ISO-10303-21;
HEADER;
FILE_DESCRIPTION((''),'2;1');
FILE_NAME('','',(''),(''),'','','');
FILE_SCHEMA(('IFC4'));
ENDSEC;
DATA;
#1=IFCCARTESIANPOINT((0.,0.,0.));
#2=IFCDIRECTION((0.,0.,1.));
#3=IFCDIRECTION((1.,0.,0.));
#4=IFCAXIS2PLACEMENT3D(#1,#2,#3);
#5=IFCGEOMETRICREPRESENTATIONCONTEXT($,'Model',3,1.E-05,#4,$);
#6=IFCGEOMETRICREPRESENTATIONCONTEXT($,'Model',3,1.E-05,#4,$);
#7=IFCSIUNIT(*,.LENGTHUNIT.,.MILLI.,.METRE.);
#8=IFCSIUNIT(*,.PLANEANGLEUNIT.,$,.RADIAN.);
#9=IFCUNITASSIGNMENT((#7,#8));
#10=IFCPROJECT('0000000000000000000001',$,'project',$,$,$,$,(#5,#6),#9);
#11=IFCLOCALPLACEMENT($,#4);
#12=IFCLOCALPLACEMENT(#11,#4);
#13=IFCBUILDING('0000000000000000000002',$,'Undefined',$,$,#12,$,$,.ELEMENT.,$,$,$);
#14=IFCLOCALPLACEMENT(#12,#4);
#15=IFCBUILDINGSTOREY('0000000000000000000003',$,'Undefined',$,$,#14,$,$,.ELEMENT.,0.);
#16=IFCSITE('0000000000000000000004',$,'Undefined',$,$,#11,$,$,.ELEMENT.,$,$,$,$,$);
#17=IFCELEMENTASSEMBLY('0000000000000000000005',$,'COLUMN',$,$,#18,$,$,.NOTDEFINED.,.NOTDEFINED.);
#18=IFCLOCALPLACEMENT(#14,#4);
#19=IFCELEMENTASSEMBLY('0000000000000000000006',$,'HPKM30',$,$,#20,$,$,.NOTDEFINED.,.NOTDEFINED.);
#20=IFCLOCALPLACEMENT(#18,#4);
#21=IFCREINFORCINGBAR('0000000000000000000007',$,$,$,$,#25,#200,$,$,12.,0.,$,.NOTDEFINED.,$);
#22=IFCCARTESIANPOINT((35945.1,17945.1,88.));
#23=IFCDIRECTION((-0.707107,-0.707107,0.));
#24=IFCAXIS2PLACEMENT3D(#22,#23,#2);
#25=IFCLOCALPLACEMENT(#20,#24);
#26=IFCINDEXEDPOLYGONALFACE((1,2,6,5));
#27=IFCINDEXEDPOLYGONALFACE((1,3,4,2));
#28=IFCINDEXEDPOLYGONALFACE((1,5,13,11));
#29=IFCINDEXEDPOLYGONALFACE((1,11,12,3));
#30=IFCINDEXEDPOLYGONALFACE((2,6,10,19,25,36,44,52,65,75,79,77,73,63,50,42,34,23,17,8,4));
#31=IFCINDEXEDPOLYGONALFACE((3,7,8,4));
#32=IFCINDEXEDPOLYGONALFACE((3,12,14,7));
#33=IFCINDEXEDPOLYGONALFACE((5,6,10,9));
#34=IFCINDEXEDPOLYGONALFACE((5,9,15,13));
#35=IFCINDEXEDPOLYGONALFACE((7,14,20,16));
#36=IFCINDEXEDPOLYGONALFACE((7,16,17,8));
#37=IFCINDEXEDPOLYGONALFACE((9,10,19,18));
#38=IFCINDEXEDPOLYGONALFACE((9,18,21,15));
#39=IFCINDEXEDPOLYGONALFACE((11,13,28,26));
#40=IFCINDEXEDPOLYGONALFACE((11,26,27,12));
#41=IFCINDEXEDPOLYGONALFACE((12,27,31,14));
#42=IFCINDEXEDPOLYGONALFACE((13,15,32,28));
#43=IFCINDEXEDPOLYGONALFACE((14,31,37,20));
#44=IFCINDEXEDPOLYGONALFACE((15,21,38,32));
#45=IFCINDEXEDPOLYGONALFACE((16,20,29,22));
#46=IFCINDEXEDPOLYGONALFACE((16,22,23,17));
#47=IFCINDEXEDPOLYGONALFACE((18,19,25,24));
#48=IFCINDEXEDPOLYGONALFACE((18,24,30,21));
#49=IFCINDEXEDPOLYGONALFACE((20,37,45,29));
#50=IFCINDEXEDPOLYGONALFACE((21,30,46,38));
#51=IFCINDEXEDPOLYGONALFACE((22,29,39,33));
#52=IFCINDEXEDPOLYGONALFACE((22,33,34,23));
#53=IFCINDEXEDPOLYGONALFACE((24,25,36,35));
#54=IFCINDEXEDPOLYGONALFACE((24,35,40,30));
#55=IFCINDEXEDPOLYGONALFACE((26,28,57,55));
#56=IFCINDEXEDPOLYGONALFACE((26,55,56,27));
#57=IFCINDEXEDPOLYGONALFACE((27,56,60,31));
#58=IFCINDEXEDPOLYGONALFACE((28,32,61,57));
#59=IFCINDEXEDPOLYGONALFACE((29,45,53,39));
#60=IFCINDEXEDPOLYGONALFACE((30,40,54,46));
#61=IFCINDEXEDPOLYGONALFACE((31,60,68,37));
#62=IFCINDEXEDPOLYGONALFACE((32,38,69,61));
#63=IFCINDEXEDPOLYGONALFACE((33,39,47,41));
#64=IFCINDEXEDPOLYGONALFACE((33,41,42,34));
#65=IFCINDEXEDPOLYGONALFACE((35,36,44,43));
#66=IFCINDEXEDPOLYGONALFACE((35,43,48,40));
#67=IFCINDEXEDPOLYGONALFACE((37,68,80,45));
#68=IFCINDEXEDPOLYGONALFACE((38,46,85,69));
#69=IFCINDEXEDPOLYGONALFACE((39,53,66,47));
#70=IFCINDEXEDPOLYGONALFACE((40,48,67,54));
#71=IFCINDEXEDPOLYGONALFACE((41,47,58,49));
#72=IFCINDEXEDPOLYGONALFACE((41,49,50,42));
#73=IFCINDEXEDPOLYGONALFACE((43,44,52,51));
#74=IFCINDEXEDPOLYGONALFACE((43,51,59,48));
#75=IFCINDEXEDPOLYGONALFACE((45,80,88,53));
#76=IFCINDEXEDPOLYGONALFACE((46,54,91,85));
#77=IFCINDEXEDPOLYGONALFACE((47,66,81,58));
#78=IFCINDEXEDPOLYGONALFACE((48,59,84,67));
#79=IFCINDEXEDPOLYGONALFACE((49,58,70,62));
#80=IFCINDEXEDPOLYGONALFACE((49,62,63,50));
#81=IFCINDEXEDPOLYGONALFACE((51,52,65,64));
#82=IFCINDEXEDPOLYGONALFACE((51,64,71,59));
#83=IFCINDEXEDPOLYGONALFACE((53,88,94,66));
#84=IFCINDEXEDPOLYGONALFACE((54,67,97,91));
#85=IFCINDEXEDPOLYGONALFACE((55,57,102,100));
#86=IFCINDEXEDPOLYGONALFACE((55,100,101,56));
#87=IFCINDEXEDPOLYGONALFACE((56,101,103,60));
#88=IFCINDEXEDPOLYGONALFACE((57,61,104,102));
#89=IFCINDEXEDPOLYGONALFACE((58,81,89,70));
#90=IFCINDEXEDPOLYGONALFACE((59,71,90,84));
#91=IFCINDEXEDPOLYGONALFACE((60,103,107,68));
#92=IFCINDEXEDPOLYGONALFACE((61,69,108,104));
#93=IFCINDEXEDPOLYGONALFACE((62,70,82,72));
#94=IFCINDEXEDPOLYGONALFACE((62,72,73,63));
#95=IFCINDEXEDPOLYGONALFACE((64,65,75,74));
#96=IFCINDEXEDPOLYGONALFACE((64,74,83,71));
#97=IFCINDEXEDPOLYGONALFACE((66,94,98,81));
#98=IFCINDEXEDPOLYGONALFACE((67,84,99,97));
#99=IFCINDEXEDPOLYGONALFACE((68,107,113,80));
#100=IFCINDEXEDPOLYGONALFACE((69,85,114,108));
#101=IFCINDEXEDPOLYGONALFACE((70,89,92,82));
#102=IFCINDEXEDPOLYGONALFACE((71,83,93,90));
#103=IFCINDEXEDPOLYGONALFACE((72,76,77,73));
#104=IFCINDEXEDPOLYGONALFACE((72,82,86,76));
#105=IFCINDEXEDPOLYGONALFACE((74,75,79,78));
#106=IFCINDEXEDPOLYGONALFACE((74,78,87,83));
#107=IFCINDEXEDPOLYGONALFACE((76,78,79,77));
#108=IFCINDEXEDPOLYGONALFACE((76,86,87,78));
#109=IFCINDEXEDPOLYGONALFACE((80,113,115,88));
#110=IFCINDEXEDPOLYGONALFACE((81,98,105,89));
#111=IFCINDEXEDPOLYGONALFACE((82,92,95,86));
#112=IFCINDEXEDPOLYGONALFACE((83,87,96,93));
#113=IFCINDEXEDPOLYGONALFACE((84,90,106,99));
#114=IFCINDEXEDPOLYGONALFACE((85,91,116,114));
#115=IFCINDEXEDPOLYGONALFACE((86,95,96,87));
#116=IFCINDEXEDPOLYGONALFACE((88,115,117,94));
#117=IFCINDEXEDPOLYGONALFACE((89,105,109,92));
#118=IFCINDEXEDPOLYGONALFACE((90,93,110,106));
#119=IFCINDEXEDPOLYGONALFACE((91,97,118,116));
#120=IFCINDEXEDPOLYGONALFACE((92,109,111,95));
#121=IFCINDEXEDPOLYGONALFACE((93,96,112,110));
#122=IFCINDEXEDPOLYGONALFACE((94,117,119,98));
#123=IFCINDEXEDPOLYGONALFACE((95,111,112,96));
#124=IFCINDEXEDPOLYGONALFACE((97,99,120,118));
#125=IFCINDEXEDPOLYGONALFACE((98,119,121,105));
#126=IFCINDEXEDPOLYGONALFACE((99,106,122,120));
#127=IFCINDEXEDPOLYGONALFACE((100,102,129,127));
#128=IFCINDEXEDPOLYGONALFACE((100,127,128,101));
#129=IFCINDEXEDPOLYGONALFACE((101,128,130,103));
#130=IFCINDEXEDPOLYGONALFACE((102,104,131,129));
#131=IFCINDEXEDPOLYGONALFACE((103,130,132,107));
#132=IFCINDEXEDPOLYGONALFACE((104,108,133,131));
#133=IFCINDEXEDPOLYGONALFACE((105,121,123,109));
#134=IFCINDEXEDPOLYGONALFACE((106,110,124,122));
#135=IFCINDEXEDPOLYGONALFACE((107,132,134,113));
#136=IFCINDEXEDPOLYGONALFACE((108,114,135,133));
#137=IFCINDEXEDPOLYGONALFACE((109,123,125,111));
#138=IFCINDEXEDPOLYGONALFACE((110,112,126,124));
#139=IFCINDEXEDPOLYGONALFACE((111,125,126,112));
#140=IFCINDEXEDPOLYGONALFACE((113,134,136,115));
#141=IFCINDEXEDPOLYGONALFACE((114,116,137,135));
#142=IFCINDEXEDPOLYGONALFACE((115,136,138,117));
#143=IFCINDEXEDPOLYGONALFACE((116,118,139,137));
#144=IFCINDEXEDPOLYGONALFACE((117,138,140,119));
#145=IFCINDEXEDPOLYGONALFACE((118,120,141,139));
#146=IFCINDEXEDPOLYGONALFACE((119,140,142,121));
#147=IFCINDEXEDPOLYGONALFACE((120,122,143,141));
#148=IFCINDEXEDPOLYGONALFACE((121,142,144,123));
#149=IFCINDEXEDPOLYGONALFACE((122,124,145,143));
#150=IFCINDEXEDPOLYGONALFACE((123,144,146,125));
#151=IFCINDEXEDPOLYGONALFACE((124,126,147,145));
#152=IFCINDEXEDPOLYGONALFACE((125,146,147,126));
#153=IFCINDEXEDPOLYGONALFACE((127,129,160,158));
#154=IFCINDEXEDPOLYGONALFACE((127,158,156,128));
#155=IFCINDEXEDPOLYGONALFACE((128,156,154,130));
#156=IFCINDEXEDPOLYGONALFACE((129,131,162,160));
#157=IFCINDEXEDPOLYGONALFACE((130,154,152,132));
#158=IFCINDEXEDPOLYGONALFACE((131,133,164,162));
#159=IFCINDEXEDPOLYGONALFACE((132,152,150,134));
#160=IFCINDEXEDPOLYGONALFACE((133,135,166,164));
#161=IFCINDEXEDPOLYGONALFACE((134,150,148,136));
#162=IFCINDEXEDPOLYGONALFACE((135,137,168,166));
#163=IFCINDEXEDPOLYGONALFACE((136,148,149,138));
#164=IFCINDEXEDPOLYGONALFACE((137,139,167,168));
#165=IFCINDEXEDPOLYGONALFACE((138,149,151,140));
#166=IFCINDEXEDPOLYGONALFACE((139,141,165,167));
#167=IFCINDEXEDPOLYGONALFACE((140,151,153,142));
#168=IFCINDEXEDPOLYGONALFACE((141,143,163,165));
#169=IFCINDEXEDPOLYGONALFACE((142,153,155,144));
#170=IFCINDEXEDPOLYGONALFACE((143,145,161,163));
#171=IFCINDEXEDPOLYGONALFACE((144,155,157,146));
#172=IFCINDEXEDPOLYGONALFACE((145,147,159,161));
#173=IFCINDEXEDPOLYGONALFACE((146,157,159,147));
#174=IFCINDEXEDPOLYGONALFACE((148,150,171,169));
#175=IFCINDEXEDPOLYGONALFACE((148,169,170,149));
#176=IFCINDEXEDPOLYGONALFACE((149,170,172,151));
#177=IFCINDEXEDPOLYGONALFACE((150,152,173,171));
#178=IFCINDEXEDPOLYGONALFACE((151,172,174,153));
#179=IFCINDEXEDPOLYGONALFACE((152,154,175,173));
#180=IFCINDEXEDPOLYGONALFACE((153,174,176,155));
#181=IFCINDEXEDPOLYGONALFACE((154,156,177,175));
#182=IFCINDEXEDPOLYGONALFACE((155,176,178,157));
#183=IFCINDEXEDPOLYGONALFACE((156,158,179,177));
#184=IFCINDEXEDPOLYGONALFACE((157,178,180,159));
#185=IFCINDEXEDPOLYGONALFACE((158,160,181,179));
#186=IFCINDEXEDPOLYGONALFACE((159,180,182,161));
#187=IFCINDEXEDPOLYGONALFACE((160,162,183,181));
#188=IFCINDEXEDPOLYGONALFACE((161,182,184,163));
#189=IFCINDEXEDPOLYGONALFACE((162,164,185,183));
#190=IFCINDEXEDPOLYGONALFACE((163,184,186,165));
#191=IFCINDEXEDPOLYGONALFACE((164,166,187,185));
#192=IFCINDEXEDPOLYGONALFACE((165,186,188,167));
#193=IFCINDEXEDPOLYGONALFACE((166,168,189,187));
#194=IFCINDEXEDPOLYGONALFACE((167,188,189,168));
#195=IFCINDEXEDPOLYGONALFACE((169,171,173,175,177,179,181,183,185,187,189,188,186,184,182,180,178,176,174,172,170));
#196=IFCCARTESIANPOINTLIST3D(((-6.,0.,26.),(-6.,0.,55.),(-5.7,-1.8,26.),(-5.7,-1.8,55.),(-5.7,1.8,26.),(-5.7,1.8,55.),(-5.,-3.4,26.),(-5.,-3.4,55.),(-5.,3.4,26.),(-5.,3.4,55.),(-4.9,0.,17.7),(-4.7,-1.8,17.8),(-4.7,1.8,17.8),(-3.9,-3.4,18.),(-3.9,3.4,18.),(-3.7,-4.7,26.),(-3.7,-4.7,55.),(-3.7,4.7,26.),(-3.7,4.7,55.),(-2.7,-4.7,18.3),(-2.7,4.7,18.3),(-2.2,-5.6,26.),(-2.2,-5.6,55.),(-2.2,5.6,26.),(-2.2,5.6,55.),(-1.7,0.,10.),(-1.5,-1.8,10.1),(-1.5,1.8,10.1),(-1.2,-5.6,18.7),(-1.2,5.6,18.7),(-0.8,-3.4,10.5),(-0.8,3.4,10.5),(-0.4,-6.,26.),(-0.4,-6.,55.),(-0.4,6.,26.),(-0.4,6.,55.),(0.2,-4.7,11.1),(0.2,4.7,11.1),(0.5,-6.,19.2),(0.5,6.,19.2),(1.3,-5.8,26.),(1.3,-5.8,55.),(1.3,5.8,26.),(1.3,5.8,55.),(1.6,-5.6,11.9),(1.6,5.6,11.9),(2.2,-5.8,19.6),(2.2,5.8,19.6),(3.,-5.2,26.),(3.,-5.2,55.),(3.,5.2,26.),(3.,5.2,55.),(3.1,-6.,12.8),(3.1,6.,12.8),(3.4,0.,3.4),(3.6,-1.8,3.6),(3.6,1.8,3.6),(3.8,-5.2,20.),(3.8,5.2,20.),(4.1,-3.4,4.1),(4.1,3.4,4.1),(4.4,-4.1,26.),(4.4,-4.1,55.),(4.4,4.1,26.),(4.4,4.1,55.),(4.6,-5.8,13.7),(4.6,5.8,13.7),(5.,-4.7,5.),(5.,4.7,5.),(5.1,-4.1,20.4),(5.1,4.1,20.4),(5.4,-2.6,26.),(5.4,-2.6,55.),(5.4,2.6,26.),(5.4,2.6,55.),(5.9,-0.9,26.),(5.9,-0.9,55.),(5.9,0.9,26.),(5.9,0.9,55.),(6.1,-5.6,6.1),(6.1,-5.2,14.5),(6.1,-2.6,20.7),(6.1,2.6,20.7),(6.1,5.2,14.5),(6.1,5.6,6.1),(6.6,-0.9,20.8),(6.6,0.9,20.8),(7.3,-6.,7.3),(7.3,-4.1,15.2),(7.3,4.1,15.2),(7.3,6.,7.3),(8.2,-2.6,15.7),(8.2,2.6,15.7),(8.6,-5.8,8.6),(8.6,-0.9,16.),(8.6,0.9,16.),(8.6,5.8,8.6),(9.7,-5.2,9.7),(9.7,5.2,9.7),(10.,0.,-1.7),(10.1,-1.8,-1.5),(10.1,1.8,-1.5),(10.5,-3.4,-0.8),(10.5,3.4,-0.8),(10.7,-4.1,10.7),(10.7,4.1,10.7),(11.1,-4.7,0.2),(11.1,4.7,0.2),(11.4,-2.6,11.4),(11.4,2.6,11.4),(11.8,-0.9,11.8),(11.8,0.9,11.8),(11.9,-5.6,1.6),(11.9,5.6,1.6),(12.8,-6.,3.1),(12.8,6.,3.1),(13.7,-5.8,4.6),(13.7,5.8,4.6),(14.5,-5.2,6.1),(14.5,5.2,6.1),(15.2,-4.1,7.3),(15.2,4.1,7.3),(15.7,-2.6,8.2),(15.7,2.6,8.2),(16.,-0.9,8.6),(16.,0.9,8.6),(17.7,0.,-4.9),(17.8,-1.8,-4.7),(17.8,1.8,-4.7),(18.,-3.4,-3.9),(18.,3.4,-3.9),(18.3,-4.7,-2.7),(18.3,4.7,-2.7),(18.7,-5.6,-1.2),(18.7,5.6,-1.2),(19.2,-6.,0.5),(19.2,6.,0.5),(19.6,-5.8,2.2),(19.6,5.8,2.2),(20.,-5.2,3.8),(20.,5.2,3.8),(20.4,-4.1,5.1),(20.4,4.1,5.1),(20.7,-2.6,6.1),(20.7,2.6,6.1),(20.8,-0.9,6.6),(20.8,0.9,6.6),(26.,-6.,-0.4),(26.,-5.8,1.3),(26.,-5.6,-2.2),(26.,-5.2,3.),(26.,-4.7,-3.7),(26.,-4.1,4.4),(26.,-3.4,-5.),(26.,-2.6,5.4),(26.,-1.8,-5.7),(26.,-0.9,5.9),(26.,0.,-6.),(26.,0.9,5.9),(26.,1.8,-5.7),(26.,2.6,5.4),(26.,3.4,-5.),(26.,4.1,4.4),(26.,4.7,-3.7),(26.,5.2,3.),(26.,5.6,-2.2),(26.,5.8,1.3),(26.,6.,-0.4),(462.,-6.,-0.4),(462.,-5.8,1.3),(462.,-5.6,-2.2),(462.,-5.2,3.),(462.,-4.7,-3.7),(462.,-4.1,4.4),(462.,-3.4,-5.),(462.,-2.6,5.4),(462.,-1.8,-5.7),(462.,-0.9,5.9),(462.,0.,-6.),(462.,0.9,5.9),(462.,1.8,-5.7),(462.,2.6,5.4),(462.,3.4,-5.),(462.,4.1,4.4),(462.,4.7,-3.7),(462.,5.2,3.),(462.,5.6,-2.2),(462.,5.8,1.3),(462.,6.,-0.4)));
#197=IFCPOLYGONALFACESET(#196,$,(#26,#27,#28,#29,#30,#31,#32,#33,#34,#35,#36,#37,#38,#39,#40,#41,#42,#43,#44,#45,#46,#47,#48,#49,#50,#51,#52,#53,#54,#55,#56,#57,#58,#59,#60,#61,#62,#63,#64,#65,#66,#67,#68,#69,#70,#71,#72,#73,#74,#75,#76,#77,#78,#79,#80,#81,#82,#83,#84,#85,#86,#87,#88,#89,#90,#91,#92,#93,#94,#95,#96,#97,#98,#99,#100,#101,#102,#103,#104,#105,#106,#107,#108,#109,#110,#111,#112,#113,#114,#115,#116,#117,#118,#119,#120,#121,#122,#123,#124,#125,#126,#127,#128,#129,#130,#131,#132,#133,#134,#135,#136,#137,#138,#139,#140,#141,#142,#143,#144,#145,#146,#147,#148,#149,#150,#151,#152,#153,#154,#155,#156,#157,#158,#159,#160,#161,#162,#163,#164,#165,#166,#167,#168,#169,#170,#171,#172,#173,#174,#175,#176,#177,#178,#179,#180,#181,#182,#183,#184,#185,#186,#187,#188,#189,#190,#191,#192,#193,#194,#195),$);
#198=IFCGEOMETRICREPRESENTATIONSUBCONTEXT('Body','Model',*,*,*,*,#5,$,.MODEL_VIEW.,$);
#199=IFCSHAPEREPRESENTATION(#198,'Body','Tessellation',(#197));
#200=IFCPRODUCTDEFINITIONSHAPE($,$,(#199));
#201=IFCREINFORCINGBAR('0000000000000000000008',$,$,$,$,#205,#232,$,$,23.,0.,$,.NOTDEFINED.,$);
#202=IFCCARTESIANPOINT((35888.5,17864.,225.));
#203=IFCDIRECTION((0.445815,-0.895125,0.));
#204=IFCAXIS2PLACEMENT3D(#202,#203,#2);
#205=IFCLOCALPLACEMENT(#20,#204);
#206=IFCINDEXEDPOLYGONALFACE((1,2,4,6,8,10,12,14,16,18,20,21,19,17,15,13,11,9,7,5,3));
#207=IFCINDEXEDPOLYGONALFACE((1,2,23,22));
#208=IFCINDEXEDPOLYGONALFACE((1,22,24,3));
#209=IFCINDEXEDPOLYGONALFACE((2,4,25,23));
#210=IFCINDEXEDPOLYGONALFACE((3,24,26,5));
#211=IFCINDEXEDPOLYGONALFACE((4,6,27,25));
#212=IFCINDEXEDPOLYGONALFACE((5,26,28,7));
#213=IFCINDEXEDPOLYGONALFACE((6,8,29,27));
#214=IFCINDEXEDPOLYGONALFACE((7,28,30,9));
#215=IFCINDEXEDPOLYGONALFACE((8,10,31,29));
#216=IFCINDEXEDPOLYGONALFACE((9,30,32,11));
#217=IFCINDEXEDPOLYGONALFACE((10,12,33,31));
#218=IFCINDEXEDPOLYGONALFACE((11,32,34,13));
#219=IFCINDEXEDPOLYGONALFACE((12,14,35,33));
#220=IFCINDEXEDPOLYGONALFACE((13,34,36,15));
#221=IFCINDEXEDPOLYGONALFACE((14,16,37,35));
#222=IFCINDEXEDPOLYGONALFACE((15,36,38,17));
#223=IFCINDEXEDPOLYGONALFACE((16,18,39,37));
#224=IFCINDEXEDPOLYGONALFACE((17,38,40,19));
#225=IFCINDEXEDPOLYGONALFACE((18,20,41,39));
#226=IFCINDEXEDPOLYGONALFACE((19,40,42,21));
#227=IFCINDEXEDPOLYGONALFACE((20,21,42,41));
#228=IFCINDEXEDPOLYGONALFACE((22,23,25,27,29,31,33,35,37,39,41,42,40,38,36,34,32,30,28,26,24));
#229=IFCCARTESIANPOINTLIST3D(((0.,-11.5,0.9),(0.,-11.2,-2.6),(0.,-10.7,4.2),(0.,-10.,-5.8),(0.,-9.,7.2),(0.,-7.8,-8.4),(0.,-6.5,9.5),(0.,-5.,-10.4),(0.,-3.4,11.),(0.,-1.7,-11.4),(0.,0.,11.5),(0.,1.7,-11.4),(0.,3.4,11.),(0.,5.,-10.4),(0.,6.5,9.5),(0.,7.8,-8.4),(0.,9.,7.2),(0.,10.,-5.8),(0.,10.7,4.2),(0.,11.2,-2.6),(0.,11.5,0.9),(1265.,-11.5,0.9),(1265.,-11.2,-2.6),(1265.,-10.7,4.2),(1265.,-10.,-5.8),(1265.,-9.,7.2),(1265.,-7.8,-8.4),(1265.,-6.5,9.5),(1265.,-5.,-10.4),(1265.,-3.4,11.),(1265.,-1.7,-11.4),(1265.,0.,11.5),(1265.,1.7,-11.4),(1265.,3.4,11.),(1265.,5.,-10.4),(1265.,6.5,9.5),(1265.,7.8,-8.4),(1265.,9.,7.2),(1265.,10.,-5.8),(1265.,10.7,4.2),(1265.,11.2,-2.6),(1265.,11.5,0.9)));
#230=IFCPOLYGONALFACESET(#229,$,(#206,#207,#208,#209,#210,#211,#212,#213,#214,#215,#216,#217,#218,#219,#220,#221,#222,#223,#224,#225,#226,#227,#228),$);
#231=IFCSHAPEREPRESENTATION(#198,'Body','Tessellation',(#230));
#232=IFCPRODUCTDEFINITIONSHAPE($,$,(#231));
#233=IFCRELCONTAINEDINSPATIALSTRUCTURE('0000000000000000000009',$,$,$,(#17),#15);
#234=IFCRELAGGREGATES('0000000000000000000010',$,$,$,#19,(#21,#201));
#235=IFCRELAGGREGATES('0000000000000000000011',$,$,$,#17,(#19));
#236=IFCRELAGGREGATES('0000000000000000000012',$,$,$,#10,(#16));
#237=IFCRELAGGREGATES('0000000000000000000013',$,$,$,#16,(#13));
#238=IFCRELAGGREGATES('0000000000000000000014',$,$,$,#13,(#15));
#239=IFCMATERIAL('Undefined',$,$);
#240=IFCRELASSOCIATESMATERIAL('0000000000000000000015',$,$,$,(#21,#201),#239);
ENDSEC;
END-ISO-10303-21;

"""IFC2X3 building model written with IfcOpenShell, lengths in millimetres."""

from ifc_helpers import new_model, entity, si_unit, frame, origin_with_axes, place, context, subcontext, project, spatial, source, transform, mapped, material, element, aggregate, save


model = new_model("IFC2X3")

# Units and contexts
model_context_1 = context("Model", 3, precision=1e-05, world=origin_with_axes())
model_context_2 = context("Model", 3, precision=1e-05, world=origin_with_axes())
body_context = subcontext(model_context_1, "Body", "Model", "MODEL_VIEW")
ifc_project = project(units=[si_unit("LENGTHUNIT", "METRE", prefix="MILLI"), si_unit("PLANEANGLEUNIT", "RADIAN")], contexts=[model_context_1, model_context_2])

# Site, building, storey
site_placement = place(None, origin_with_axes())
site = spatial("IfcSite", under=ifc_project, at=site_placement, Name="Undefined", CompositionType="ELEMENT")
building_placement = place(site_placement, origin_with_axes())
building = spatial("IfcBuilding", under=site, at=building_placement, Name="Undefined", CompositionType="ELEMENT")
storey_placement = place(building_placement, origin_with_axes())
storey = spatial("IfcBuildingStorey", under=building, at=storey_placement, Name="Undefined", CompositionType="ELEMENT", Elevation=0.0)

# Element assembly
assembly_1_placement = place(storey_placement, origin_with_axes())
assembly_1 = element("IfcElementAssembly", 1, at=assembly_1_placement, inside=storey, Name="COLUMN", AssemblyPlace="NOTDEFINED", PredefinedType="NOTDEFINED")

# Element assembly
assembly_2_placement = place(assembly_1_placement, origin_with_axes())
assembly_2 = element("IfcElementAssembly", 2, at=assembly_2_placement, Name="HPKM30", AssemblyPlace="NOTDEFINED", PredefinedType="NOTDEFINED")

# Shared definitions
ifc_material_1 = material(Name="Undefined")

# Reinforcing bars
shared_shape_1 = source(origin_with_axes(), body_context, "Body", "AdvancedSweptSolid", [
    entity("IfcSweptDiskSolid", entity("IfcCompositeCurve", [entity("IfcCompositeCurveSegment", "CONTINUOUS", True, entity("IfcTrimmedCurve", entity("IfcLine", entity("IfcCartesianPoint", [0.0, 0.0, 0.0]), entity("IfcVector", entity("IfcDirection", [0.0, 0.0, -1.0]), 1.0)), [entity("IfcParameterValue", 0.0)], [entity("IfcParameterValue", 29.0)], True, "PARAMETER")), entity("IfcCompositeCurveSegment", "CONTINUOUS", True, entity("IfcTrimmedCurve", entity("IfcCircle", entity("IfcAxis2Placement3D", entity("IfcCartesianPoint", [26.0, 0.0, -29.0]), entity("IfcDirection", [0.0, -1.0, 0.0]), entity("IfcDirection", [-1.0, 0.0, 0.0])), 26.0), [entity("IfcParameterValue", 0.0)], [entity("IfcParameterValue", 1.570796)], True, "PARAMETER")), entity("IfcCompositeCurveSegment", "DISCONTINUOUS", True, entity("IfcTrimmedCurve", entity("IfcLine", entity("IfcCartesianPoint", [26.0, 0.0, -55.0]), entity("IfcVector", entity("IfcDirection", [1.0, 0.0, 0.0]), 1.0)), [entity("IfcParameterValue", 0.0)], [entity("IfcParameterValue", 436.0)], True, "PARAMETER"))], False), 6.0, None, 0.0, 466.6),
])
reinforcing_bar_1_placement = place(assembly_2_placement, frame((35945.1, 17945.1, 88.0), z_axis=(-0.707107, -0.707107, 0.0), x_axis=(0.0, 0.0, 1.0)))
reinforcing_bar_1 = element("IfcReinforcingBar", 3, at=reinforcing_bar_1_placement, material=ifc_material_1, BarRole="NOTDEFINED", CrossSectionArea=0.0, NominalDiameter=12.0, context=body_context, shape_type="MappedRepresentation", body=[
    mapped(shared_shape_1, transform((0.0, 0.0, 55.0))),
])
shared_shape_2 = source(origin_with_axes(), body_context, "Body", "AdvancedSweptSolid", [
    entity("IfcSweptDiskSolid", entity("IfcTrimmedCurve", entity("IfcLine", entity("IfcCartesianPoint", [0.0, 0.0, 0.0]), entity("IfcVector", entity("IfcDirection", [1.0, 0.0, 0.0]), 1.0)), [entity("IfcParameterValue", 0.0)], [entity("IfcParameterValue", 1265.0)], True, "PARAMETER"), 11.5, None, 0.0, 1265.0),
])
reinforcing_bar_2_placement = place(assembly_2_placement, frame((35888.5, 17864.0, 225.0), z_axis=(0.445815, -0.895125, 0.0), x_axis=(0.0, 0.0, 1.0)))
reinforcing_bar_2 = element("IfcReinforcingBar", 4, at=reinforcing_bar_2_placement, material=ifc_material_1, BarRole="NOTDEFINED", CrossSectionArea=0.0, NominalDiameter=23.0, context=body_context, shape_type="MappedRepresentation", body=[
    mapped(shared_shape_2, transform((0.0, 0.0, 0.0))),
])
aggregate(assembly_2, [reinforcing_bar_1, reinforcing_bar_2])
aggregate(assembly_1, [assembly_2])

save(model, "model.ifc")
